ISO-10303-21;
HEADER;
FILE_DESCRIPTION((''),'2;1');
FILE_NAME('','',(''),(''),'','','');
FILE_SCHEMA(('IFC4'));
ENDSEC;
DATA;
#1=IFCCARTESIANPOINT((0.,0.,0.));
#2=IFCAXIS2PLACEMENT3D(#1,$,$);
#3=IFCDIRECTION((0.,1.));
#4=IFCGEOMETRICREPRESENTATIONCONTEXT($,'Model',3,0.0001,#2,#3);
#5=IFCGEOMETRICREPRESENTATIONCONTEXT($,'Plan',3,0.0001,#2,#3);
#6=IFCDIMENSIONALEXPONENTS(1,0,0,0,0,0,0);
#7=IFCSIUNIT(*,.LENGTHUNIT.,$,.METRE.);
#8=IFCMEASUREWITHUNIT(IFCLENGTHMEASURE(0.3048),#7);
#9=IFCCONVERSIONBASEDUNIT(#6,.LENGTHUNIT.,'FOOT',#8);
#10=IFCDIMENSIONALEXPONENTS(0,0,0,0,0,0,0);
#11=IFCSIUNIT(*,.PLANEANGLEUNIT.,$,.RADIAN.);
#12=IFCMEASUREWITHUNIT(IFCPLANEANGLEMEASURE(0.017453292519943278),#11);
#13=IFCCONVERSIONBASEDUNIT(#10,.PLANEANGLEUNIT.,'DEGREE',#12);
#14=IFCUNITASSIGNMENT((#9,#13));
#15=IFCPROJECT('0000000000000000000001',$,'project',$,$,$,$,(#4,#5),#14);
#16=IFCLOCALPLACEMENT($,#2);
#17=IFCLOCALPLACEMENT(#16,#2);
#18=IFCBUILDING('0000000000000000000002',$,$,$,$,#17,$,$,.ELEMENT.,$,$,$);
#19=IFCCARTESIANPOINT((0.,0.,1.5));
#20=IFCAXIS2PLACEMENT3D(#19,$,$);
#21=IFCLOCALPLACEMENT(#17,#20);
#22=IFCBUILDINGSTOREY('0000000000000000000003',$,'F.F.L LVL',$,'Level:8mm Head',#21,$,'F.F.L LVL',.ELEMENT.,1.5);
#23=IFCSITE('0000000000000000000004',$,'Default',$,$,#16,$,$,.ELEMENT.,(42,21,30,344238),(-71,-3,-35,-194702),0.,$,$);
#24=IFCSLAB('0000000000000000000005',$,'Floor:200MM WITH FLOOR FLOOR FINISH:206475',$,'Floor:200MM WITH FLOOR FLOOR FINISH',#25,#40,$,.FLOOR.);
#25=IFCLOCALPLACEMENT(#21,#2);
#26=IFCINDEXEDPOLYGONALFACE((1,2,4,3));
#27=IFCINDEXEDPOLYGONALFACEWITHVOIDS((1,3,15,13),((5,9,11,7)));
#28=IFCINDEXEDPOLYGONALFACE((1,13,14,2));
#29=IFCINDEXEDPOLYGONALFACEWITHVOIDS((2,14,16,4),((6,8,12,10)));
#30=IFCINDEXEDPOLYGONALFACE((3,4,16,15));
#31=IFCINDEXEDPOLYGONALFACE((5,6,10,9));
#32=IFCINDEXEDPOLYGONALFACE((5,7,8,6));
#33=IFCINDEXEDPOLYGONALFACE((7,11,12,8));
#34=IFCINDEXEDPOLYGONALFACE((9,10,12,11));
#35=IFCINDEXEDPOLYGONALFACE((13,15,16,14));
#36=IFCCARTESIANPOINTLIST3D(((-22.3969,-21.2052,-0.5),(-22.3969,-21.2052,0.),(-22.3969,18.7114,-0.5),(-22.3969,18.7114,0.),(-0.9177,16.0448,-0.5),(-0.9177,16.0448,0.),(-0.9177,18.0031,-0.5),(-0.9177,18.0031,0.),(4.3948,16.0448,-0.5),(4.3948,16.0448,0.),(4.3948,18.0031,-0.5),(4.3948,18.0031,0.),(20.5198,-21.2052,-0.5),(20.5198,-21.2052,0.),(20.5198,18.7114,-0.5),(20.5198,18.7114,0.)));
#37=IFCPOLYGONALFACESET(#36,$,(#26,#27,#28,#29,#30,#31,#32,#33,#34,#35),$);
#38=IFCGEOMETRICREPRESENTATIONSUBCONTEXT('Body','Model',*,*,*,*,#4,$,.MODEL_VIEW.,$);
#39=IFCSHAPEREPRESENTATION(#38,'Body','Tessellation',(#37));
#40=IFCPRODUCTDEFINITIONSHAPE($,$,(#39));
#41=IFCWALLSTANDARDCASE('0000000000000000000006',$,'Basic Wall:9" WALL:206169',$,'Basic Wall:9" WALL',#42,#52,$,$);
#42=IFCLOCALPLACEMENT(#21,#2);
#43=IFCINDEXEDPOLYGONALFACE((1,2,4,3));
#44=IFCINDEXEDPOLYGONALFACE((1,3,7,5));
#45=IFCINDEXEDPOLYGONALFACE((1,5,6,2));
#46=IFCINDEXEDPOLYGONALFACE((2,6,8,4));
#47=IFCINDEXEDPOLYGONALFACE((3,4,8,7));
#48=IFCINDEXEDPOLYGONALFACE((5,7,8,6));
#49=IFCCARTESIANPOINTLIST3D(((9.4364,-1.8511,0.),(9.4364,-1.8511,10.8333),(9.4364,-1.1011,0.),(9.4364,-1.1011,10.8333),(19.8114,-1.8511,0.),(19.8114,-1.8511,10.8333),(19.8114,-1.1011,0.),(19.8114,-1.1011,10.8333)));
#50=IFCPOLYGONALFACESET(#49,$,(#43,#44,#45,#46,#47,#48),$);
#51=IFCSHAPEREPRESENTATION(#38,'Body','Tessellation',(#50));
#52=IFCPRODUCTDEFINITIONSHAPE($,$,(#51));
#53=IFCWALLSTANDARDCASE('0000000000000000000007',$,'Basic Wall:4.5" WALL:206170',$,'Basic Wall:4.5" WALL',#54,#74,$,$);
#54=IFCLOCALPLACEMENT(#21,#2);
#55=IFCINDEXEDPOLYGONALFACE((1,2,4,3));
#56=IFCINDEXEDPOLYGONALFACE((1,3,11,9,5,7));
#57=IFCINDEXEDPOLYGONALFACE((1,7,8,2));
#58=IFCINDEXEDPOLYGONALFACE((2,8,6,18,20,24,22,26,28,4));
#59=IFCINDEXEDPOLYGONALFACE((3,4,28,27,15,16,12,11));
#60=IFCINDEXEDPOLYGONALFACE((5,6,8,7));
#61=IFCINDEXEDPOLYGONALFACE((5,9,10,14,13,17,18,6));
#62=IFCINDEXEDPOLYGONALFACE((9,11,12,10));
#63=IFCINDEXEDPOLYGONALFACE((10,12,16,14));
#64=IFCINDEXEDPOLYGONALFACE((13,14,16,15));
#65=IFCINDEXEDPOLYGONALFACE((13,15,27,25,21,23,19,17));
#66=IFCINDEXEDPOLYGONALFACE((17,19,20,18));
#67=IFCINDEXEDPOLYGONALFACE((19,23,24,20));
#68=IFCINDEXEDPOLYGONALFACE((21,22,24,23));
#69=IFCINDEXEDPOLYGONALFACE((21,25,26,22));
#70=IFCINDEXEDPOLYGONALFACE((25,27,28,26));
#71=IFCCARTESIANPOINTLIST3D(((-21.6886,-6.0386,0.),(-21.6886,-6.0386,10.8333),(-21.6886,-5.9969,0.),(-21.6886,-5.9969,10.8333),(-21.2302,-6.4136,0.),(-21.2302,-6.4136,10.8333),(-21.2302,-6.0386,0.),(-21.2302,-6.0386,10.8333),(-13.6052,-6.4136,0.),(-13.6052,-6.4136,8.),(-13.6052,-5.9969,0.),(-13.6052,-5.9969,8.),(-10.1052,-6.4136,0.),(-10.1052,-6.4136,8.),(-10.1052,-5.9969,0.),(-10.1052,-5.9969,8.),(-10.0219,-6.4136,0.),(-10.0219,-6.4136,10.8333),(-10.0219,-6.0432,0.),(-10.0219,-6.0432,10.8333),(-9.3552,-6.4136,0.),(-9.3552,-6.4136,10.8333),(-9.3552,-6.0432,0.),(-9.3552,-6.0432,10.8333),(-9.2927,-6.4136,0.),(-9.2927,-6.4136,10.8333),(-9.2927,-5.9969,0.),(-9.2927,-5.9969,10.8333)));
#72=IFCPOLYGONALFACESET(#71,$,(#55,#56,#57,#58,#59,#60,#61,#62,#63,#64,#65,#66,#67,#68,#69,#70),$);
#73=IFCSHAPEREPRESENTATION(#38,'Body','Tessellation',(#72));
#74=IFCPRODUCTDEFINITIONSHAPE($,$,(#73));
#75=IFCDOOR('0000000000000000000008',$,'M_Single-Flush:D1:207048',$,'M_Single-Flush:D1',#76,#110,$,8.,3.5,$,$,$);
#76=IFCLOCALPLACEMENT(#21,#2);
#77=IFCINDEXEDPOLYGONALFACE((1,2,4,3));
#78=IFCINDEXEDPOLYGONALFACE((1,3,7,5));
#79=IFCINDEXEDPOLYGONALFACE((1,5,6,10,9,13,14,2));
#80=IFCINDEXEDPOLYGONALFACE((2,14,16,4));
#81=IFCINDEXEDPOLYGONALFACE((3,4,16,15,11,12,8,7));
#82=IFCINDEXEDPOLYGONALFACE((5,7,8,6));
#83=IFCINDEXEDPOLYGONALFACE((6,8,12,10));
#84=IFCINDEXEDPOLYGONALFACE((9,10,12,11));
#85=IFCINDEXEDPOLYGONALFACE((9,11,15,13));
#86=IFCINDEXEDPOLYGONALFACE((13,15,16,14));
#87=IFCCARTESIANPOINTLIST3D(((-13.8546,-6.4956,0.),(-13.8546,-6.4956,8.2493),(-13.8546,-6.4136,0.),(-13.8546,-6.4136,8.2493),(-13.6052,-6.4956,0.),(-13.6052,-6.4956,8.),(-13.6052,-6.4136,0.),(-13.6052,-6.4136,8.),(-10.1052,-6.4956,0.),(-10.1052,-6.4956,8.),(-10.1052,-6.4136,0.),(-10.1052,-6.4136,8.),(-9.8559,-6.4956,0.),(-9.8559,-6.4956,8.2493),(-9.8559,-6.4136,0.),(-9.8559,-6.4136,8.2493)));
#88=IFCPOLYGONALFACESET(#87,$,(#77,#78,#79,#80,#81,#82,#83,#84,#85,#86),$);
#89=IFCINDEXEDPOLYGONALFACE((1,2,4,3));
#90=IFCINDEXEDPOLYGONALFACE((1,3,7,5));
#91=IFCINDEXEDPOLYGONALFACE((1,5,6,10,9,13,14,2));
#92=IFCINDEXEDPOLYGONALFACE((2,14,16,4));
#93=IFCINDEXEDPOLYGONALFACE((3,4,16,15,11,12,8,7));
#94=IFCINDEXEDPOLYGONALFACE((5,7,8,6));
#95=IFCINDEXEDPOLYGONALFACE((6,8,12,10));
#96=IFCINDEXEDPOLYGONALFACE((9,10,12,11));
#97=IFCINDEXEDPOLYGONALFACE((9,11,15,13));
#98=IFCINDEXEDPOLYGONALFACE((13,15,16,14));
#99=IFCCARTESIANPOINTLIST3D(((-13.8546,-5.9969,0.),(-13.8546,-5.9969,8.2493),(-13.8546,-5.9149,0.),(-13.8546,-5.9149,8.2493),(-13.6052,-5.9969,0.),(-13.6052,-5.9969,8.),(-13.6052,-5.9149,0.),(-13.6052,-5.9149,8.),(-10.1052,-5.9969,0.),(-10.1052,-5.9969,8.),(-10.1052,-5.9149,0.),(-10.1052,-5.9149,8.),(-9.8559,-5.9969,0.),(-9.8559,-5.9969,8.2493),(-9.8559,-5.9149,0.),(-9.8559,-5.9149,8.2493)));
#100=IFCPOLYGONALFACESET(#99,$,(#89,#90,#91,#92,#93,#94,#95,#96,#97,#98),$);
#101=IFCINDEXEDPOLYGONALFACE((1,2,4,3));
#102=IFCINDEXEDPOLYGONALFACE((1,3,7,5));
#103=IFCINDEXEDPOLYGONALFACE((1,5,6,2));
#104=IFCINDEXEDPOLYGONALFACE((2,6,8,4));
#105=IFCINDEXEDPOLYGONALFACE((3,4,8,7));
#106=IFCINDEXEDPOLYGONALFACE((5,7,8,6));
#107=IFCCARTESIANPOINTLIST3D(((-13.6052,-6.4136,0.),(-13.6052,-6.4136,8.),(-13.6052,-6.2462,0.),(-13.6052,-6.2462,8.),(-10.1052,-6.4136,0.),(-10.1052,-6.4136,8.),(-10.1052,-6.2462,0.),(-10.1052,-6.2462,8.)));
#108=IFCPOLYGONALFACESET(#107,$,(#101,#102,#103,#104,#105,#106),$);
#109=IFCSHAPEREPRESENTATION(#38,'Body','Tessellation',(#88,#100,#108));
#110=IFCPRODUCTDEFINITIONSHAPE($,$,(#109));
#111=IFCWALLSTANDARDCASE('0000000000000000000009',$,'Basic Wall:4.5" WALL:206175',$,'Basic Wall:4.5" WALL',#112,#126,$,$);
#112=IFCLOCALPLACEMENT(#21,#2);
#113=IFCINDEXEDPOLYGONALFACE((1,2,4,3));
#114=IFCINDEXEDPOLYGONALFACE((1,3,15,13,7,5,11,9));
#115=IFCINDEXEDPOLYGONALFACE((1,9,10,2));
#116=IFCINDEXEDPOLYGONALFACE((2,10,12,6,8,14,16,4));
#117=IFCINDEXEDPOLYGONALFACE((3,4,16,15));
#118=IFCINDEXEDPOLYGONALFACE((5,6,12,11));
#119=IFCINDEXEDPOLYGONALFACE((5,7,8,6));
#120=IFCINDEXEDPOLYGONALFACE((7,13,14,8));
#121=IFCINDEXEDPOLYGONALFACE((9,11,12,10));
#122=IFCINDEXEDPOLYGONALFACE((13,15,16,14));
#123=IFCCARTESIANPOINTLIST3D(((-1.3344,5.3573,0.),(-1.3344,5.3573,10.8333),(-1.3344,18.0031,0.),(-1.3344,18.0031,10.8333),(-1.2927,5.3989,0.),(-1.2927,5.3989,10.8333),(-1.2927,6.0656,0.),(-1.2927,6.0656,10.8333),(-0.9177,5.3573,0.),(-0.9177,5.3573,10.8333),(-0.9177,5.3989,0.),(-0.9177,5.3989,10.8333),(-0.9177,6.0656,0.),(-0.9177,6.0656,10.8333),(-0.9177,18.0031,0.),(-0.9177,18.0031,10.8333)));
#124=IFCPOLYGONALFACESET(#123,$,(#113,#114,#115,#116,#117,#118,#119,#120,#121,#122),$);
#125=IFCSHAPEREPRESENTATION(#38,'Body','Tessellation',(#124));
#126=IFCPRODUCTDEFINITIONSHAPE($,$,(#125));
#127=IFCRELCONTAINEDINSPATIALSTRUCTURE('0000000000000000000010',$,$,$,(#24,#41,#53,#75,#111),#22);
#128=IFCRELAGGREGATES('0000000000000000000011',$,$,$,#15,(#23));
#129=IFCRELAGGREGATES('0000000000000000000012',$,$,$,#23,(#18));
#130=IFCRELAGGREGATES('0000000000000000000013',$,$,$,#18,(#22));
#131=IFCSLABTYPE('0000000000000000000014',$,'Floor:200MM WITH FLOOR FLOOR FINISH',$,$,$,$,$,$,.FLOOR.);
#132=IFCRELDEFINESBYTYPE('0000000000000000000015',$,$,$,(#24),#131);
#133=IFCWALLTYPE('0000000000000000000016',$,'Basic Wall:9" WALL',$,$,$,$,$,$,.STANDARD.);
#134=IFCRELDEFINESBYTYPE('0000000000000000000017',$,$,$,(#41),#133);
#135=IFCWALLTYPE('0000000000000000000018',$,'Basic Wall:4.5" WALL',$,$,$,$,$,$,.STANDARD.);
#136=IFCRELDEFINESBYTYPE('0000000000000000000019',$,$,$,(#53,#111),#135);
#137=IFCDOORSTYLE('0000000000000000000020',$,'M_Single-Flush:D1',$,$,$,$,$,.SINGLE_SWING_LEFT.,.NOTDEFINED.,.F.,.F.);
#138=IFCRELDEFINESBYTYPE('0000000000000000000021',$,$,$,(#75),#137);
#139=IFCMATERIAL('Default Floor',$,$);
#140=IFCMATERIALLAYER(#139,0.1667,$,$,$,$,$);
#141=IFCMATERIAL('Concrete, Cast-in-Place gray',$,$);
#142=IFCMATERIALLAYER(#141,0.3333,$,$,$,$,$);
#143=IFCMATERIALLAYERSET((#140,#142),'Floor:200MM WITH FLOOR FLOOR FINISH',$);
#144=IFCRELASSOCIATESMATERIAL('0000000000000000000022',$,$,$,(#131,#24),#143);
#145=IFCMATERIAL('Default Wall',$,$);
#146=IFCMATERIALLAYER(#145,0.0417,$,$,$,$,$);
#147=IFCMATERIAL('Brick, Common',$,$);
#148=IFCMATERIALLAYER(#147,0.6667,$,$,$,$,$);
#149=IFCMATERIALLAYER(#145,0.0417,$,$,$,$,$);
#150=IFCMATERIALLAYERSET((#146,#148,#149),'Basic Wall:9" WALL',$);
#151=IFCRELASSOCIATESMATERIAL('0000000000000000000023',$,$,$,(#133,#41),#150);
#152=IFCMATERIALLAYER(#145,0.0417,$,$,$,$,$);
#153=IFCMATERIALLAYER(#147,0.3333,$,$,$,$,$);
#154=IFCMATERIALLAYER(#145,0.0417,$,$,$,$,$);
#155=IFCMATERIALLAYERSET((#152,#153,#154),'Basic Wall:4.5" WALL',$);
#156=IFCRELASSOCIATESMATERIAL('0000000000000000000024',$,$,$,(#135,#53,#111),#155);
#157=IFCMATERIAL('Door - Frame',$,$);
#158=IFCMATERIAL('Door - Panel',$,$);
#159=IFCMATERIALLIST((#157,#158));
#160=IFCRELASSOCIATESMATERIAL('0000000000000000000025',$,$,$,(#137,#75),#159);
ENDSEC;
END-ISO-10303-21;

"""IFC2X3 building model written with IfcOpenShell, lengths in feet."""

from ifc_helpers import new_model, entity, si_unit, converted_unit, direction, frame, frame_2d, origin, origin_2d_with_axis, place, context, subcontext, project, spatial, polyline, rectangle, outline, extrude, boolean, clip, bounded_halfspace, source, transform, mapped, material, material_list, layer, layer_set, layer_usage, type_object, type_shapes, element, fill, save


model = new_model("IFC2X3")

# Units and contexts
model_context = context("Model", 3, precision=0.0001, world=origin(), true_north=direction((0.0, 1.0)))
plan_context = context("Plan", 3, precision=0.0001, world=origin(), true_north=direction((0.0, 1.0)))
body_context = subcontext(model_context, "Body", "Model", "MODEL_VIEW")
ifc_project = project(units=[converted_unit("LENGTHUNIT", "FOOT", entity("IfcLengthMeasure", 0.3048), si_unit("LENGTHUNIT", "METRE"), dimensions=[1, 0, 0, 0, 0, 0, 0]), converted_unit("PLANEANGLEUNIT", "DEGREE", entity("IfcPlaneAngleMeasure", 0.017453292519943278), si_unit("PLANEANGLEUNIT", "RADIAN"), dimensions=[0, 0, 0, 0, 0, 0, 0])], contexts=[model_context, plan_context])

# Site, building, storey
site_placement = place(None, origin())
site = spatial("IfcSite", under=ifc_project, at=site_placement, Name="Default", CompositionType="ELEMENT", RefLatitude=(42, 21, 30, 344238), RefLongitude=(-71, -3, -35, -194702), RefElevation=0.0)
building_placement = place(site_placement, origin())
building = spatial("IfcBuilding", under=site, at=building_placement, CompositionType="ELEMENT")
storey_placement = place(building_placement, frame((0.0, 0.0, 1.5)))
storey = spatial("IfcBuildingStorey", under=building, at=storey_placement, Name="F.F.L LVL", ObjectType="Level:8mm Head", LongName="F.F.L LVL", CompositionType="ELEMENT", Elevation=1.5)

# Slab, opening
ifc_material_1 = material(Name="Default Floor")
ifc_layer_1 = layer(ifc_material_1, 0.1667)
ifc_material_2 = material(Name="Concrete, Cast-in-Place gray")
ifc_layer_2 = layer(ifc_material_2, 0.3333)
ifc_layer_set_1 = layer_set([ifc_layer_1, ifc_layer_2], Name="Floor:200MM WITH FLOOR FLOOR FINISH")
ifc_layer_usage_1 = layer_usage(ifc_layer_set_1, "AXIS3", "POSITIVE", 0.0)
slab_type = type_object("IfcSlabType", Name="Floor:200MM WITH FLOOR FLOOR FINISH", PredefinedType="FLOOR", material=ifc_layer_set_1)
slab_placement = place(storey_placement, origin())
slab = element("IfcSlab", 1, at=slab_placement, inside=storey, type_object=slab_type, material=ifc_layer_usage_1, Name="Floor:200MM WITH FLOOR FLOOR FINISH:206475", ObjectType="Floor:200MM WITH FLOOR FLOOR FINISH", PredefinedType="FLOOR", context=body_context, shape_type="SweptSolid", body=[
    boolean("DIFFERENCE", extrude(rectangle(XDim=39.9167, YDim=42.9167, at=frame_2d((0.0, 0.0), x_axis=(1.0, 0.0))), frame((-0.9386, -1.2469, 0.0), z_axis=(0.0, 0.0, -1.0), x_axis=(0.0, 1.0, 0.0)), (0.0, 0.0, 1.0), 0.5), extrude(rectangle(XDim=1.9583, YDim=5.3125, at=origin_2d_with_axis()), frame((1.7385, 17.0239, -0.5), z_axis=(0.0, 0.0, 1.0), x_axis=(0.0, 1.0, 0.0)), (0.0, 0.0, 1.0), 0.5)),
])
opening_1_placement = place(slab_placement, origin())
element("IfcOpeningElement", 2, at=opening_1_placement, cuts=slab, ObjectType="Opening", context=body_context, shape_type="SweptSolid", body=[
    extrude(rectangle(XDim=5.3125, YDim=1.9583, at=origin_2d_with_axis()), frame((1.7385, 17.0239, -0.5), z_axis=(0.0, 0.0, 1.0), x_axis=(-1.0, 0.0, 0.0)), (0.0, 0.0, 1.0), 0.5),
])

# Shared definitions
ifc_material_3 = material(Name="Default Wall")
ifc_layer_3 = layer(ifc_material_3, 0.0417)
ifc_material_4 = material(Name="Brick, Common")
ifc_layer_4 = layer(ifc_material_4, 0.6667)
ifc_layer_5 = layer(ifc_material_3, 0.0417)
ifc_layer_set_2 = layer_set([ifc_layer_3, ifc_layer_4, ifc_layer_5], Name="Basic Wall:9\" WALL")
wall_type_1 = type_object("IfcWallType", Name="Basic Wall:9\" WALL", PredefinedType="STANDARD", material=ifc_layer_set_2)

# Shared definitions
ifc_material_5 = material(Name="Door - Panel")
ifc_material_6 = material(Name="Door - Frame")

# Wall
ifc_layer_usage_2 = layer_usage(ifc_layer_set_2, "AXIS2", "NEGATIVE", 0.375)
wall_1_placement = place(storey_placement, frame((19.8114, -1.4761, 0.0), z_axis=(0.0, 0.0, 1.0), x_axis=(-1.0, 0.0, 0.0)))
element("IfcWallStandardCase", 3, at=wall_1_placement, inside=storey, type_object=wall_type_1, material=ifc_layer_usage_2, Name="Basic Wall:9\" WALL:206169", ObjectType="Basic Wall:9\" WALL", context=body_context, shape_type="SweptSolid", body=[
    extrude(rectangle(XDim=10.375, YDim=0.75, at=frame_2d((5.1875, 0.0), x_axis=(-1.0, 0.0))), origin(), (0.0, 0.0, 1.0), 10.8333),
])

# Wall, opening, door
ifc_layer_6 = layer(ifc_material_3, 0.0417)
ifc_layer_7 = layer(ifc_material_4, 0.3333)
ifc_layer_8 = layer(ifc_material_3, 0.0417)
ifc_layer_set_3 = layer_set([ifc_layer_6, ifc_layer_7, ifc_layer_8], Name="Basic Wall:4.5\" WALL")
ifc_layer_usage_3 = layer_usage(ifc_layer_set_3, "AXIS2", "NEGATIVE", 0.2083)
wall_type_2 = type_object("IfcWallType", Name="Basic Wall:4.5\" WALL", PredefinedType="STANDARD", material=ifc_layer_set_3)
wall_2_placement = place(storey_placement, frame((-9.2927, -6.2052, 0.0), z_axis=(0.0, 0.0, 1.0), x_axis=(-1.0, 0.0, 0.0)))
wall_2 = element("IfcWallStandardCase", 4, at=wall_2_placement, inside=storey, type_object=wall_type_2, material=ifc_layer_usage_3, Name="Basic Wall:4.5\" WALL:206170", ObjectType="Basic Wall:4.5\" WALL", context=body_context, shape_type="Clipping", body=[
    clip(clip(clip(extrude(rectangle(XDim=12.3958, YDim=0.4167, at=frame_2d((6.1979, 0.0), x_axis=(-1.0, 0.0))), origin(), (0.0, 0.0, 1.0), 10.8333), bounded_halfspace(frame((11.9375, -0.1667, 0.0), z_axis=(0.0, -1.0, 0.0), x_axis=(0.0, 0.0, -1.0)), True, frame((11.9375, -0.1667, 0.0), z_axis=(0.0, -1.0, 0.0), x_axis=(0.0, 0.0, -1.0)), polyline([(0.0, 0.0), (0.0, 0.4583), (-10.8333, 0.4583), (-10.8333, 0.0), (0.0, 0.0)]))), bounded_halfspace(frame((11.9375, -0.1667, 10.8333), z_axis=(-1.0, 0.0, 0.0), x_axis=(0.0, 0.0, -1.0)), True, frame((11.9375, -0.1667, 10.8333), z_axis=(-1.0, 0.0, 0.0), x_axis=(0.0, 0.0, -1.0)), polyline([(0.0, 0.0), (0.0, -0.375), (10.8333, -0.375), (10.8333, 0.0), (0.0, 0.0)]))), bounded_halfspace(frame((0.7292, -0.162, 10.8333), z_axis=(0.0, -1.0, 0.0), x_axis=(0.0, 0.0, -1.0)), True, frame((0.7292, -0.162, 10.8333), z_axis=(0.0, -1.0, 0.0), x_axis=(0.0, 0.0, -1.0)), polyline([(0.0, 0.0), (0.0, -0.6667), (10.8333, -0.6667), (10.8333, 0.0), (0.0, 0.0)]))),
])
opening_2_placement = place(wall_2_placement, frame((0.8125, -0.2083, 0.0)))
opening_2 = element("IfcOpeningElement", 5, at=opening_2_placement, cuts=wall_2, ObjectType="Opening", context=body_context, shape_type="SweptSolid", body=[
    extrude(rectangle(XDim=3.5, YDim=8.0, at=frame_2d((4.0, 1.75), x_axis=(0.0, -1.0))), frame((0.0, 0.0, 0.0), z_axis=(0.0, 1.0, 0.0), x_axis=(0.0, 0.0, 1.0)), (0.0, 0.0, 1.0), 0.4167),
])
ifc_material_list_1 = material_list([ifc_material_6, ifc_material_5])
door_style_1 = type_object("IfcDoorStyle", Name="M_Single-Flush:D1", ConstructionType="NOTDEFINED", OperationType="SINGLE_SWING_LEFT", ParameterTakesPrecedence=False, Sizeable=False, material=ifc_material_list_1)
shared_shape_1 = source(origin(), body_context, "Body", "SweptSolid", [
    extrude(outline(polyline([(-1.9993, -4.187), (1.9993, -4.187), (1.9993, 4.0623), (1.75, 4.0623), (1.75, -3.9377), (-1.75, -3.9377), (-1.75, 4.0623), (-1.9993, 4.0623), (-1.9993, -4.187)])), frame((1.75, 0.4987, 4.0623), z_axis=(0.0, -1.0, 0.0), x_axis=(-1.0, 0.0, 0.0)), (0.0, 0.0, 1.0), 0.082),
    extrude(outline(polyline([(-4.187, -1.9993), (4.0623, -1.9993), (4.0623, -1.75), (-3.9377, -1.75), (-3.9377, 1.75), (4.0623, 1.75), (4.0623, 1.9993), (-4.187, 1.9993), (-4.187, -1.9993)])), frame((1.75, 0.0, 4.0623), z_axis=(0.0, -1.0, 0.0), x_axis=(0.0, 0.0, -1.0)), (0.0, 0.0, 1.0), 0.082),
    extrude(rectangle(XDim=3.5, YDim=0.1673, at=origin_2d_with_axis()), frame((1.75, 0.333, 0.0)), (0.0, 0.0, 1.0), 8.0),
])
type_shapes(door_style_1, [shared_shape_1])
door_1_placement = place(opening_2_placement, origin())
door_1 = element("IfcDoor", 6, at=door_1_placement, inside=storey, type_object=door_style_1, material=ifc_material_list_1, Name="M_Single-Flush:D1:207048", ObjectType="M_Single-Flush:D1", OverallHeight=8.0, OverallWidth=3.5, context=body_context, shape_type="MappedRepresentation", body=[
    mapped(shared_shape_1, transform((0.0, 0.0, 0.0), scale=1.0)),
])
fill(opening_2, door_1)

# Wall
ifc_layer_usage_4 = layer_usage(ifc_layer_set_3, "AXIS2", "NEGATIVE", 0.2083)
wall_3_placement = place(storey_placement, frame((-1.1261, 18.0031, 0.0), z_axis=(0.0, 0.0, 1.0), x_axis=(0.0, -1.0, 0.0)))
element("IfcWallStandardCase", 7, at=wall_3_placement, inside=storey, type_object=wall_type_2, material=ifc_layer_usage_4, Name="Basic Wall:4.5\" WALL:206175", ObjectType="Basic Wall:4.5\" WALL", context=body_context, shape_type="Clipping", body=[
    clip(extrude(rectangle(XDim=12.6458, YDim=0.4167, at=frame_2d((6.3229, 0.0), x_axis=(-1.0, 0.0))), origin(), (0.0, 0.0, 1.0), 10.8333), bounded_halfspace(frame((11.9375, -0.1667, 0.0), z_axis=(0.0, -1.0, 0.0), x_axis=(0.0, 0.0, -1.0)), True, frame((11.9375, -0.1667, 0.0), z_axis=(0.0, -1.0, 0.0), x_axis=(0.0, 0.0, -1.0)), polyline([(0.0, 0.0), (0.0, 0.6667), (-10.8333, 0.6667), (-10.8333, 0.0), (0.0, 0.0)]))),
])

save(model, "model.ifc")
